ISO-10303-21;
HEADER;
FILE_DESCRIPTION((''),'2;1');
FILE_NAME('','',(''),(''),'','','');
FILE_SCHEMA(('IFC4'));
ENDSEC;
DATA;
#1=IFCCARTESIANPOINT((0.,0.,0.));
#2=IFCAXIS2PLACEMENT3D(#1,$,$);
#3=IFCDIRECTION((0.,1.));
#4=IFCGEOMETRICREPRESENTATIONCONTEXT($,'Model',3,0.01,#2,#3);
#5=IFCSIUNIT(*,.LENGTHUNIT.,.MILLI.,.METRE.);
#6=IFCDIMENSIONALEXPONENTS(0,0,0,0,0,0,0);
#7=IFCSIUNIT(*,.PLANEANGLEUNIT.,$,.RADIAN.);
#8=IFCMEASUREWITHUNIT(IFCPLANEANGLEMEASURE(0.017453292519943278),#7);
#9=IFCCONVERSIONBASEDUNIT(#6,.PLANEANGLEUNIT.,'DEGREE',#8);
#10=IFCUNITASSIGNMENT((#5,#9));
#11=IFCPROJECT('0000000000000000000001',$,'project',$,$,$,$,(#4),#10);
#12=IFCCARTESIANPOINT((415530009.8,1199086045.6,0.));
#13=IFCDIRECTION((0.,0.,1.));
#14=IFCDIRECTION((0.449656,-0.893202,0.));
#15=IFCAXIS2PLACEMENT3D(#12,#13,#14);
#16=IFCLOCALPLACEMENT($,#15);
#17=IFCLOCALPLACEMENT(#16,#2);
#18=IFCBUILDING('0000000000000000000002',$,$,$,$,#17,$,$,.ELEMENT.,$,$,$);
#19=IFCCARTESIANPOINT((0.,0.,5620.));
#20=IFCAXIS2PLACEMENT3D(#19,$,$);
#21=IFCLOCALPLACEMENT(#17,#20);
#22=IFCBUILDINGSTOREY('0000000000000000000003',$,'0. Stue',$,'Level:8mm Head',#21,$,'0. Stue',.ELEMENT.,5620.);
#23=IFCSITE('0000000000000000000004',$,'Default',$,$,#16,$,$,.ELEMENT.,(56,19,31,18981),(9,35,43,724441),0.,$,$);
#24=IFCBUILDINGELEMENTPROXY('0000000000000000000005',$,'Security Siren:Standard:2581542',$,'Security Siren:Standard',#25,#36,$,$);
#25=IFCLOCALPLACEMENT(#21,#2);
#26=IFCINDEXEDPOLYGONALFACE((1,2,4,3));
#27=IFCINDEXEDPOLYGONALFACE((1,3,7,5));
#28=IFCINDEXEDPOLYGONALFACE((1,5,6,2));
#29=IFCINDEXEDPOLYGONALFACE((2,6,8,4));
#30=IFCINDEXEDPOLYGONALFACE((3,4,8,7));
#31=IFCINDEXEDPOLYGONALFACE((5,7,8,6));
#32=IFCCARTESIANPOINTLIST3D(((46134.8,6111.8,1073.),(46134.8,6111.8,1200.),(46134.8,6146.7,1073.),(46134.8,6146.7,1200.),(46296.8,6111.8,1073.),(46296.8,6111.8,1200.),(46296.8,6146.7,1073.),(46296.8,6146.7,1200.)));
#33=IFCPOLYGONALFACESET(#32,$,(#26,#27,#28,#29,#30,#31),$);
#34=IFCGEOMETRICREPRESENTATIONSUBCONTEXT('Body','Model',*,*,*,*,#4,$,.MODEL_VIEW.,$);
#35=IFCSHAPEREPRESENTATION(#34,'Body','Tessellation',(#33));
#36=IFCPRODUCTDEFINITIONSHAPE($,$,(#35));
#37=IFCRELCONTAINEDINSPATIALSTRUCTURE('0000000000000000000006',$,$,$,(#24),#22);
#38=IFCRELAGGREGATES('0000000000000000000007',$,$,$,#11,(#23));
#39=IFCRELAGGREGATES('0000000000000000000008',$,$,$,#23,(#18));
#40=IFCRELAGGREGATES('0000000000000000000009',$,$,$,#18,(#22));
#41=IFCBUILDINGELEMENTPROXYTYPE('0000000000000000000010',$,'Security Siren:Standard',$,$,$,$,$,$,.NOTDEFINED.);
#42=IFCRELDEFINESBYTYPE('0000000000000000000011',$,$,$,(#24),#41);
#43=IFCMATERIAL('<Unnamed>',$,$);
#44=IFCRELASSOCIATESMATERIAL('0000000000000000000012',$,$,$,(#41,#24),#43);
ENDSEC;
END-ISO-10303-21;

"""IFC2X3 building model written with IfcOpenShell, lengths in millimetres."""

from ifc_helpers import new_model, entity, si_unit, converted_unit, direction, frame, origin, origin_2d_with_axis, place, context, subcontext, project, spatial, rectangle, extrude, source, transform, mapped, material, type_object, type_shapes, element, save


model = new_model("IFC2X3")

# Units and contexts
model_context = context("Model", 3, precision=0.01, world=origin(), true_north=direction((0.0, 1.0)))
body_context = subcontext(model_context, "Body", "Model", "MODEL_VIEW")
ifc_project = project(units=[si_unit("LENGTHUNIT", "METRE", prefix="MILLI"), converted_unit("PLANEANGLEUNIT", "DEGREE", entity("IfcPlaneAngleMeasure", 0.017453292519943278), si_unit("PLANEANGLEUNIT", "RADIAN"), dimensions=[0, 0, 0, 0, 0, 0, 0])], contexts=[model_context])

# Site, building, storey
site_placement = place(None, frame((415530009.8, 1199086045.6, 0.0), z_axis=(0.0, 0.0, 1.0), x_axis=(0.449656, -0.893202, 0.0)))
site = spatial("IfcSite", under=ifc_project, at=site_placement, Name="Default", CompositionType="ELEMENT", RefLatitude=(56, 19, 31, 18981), RefLongitude=(9, 35, 43, 724441), RefElevation=0.0)
building_placement = place(site_placement, origin())
building = spatial("IfcBuilding", under=site, at=building_placement, CompositionType="ELEMENT")
storey_placement = place(building_placement, frame((0.0, 0.0, 5620.0)))
storey = spatial("IfcBuildingStorey", under=building, at=storey_placement, Name="0. Stue", ObjectType="Level:8mm Head", LongName="0. Stue", CompositionType="ELEMENT", Elevation=5620.0)

# Building element proxy
ifc_material_1 = material(Name="<Unnamed>")
building_element_proxy_type_1 = type_object("IfcBuildingElementProxyType", Name="Security Siren:Standard", PredefinedType="NOTDEFINED", material=ifc_material_1)
shared_shape_1 = source(origin(), body_context, "Body", "SweptSolid", [
    extrude(rectangle(XDim=161.9, YDim=127.0, at=origin_2d_with_axis()), frame((0.0, -63.5, 0.0), z_axis=(0.0, 0.0, 1.0), x_axis=(-1.0, 0.0, 0.0)), (0.0, 0.0, 1.0), 34.9),
])
type_shapes(building_element_proxy_type_1, [shared_shape_1])
proxy_1_placement = place(storey_placement, frame((46215.8, 6111.8, 1200.0), z_axis=(0.0, 1.0, 0.0), x_axis=(-1.0, 0.0, 0.0)))
element("IfcBuildingElementProxy", 1, at=proxy_1_placement, inside=storey, type_object=building_element_proxy_type_1, material=ifc_material_1, Name="Security Siren:Standard:2581542", ObjectType="Security Siren:Standard", context=body_context, shape_type="MappedRepresentation", body=[
    mapped(shared_shape_1, transform((0.0, 0.0, 0.0), scale=1.0)),
])

save(model, "model.ifc")
